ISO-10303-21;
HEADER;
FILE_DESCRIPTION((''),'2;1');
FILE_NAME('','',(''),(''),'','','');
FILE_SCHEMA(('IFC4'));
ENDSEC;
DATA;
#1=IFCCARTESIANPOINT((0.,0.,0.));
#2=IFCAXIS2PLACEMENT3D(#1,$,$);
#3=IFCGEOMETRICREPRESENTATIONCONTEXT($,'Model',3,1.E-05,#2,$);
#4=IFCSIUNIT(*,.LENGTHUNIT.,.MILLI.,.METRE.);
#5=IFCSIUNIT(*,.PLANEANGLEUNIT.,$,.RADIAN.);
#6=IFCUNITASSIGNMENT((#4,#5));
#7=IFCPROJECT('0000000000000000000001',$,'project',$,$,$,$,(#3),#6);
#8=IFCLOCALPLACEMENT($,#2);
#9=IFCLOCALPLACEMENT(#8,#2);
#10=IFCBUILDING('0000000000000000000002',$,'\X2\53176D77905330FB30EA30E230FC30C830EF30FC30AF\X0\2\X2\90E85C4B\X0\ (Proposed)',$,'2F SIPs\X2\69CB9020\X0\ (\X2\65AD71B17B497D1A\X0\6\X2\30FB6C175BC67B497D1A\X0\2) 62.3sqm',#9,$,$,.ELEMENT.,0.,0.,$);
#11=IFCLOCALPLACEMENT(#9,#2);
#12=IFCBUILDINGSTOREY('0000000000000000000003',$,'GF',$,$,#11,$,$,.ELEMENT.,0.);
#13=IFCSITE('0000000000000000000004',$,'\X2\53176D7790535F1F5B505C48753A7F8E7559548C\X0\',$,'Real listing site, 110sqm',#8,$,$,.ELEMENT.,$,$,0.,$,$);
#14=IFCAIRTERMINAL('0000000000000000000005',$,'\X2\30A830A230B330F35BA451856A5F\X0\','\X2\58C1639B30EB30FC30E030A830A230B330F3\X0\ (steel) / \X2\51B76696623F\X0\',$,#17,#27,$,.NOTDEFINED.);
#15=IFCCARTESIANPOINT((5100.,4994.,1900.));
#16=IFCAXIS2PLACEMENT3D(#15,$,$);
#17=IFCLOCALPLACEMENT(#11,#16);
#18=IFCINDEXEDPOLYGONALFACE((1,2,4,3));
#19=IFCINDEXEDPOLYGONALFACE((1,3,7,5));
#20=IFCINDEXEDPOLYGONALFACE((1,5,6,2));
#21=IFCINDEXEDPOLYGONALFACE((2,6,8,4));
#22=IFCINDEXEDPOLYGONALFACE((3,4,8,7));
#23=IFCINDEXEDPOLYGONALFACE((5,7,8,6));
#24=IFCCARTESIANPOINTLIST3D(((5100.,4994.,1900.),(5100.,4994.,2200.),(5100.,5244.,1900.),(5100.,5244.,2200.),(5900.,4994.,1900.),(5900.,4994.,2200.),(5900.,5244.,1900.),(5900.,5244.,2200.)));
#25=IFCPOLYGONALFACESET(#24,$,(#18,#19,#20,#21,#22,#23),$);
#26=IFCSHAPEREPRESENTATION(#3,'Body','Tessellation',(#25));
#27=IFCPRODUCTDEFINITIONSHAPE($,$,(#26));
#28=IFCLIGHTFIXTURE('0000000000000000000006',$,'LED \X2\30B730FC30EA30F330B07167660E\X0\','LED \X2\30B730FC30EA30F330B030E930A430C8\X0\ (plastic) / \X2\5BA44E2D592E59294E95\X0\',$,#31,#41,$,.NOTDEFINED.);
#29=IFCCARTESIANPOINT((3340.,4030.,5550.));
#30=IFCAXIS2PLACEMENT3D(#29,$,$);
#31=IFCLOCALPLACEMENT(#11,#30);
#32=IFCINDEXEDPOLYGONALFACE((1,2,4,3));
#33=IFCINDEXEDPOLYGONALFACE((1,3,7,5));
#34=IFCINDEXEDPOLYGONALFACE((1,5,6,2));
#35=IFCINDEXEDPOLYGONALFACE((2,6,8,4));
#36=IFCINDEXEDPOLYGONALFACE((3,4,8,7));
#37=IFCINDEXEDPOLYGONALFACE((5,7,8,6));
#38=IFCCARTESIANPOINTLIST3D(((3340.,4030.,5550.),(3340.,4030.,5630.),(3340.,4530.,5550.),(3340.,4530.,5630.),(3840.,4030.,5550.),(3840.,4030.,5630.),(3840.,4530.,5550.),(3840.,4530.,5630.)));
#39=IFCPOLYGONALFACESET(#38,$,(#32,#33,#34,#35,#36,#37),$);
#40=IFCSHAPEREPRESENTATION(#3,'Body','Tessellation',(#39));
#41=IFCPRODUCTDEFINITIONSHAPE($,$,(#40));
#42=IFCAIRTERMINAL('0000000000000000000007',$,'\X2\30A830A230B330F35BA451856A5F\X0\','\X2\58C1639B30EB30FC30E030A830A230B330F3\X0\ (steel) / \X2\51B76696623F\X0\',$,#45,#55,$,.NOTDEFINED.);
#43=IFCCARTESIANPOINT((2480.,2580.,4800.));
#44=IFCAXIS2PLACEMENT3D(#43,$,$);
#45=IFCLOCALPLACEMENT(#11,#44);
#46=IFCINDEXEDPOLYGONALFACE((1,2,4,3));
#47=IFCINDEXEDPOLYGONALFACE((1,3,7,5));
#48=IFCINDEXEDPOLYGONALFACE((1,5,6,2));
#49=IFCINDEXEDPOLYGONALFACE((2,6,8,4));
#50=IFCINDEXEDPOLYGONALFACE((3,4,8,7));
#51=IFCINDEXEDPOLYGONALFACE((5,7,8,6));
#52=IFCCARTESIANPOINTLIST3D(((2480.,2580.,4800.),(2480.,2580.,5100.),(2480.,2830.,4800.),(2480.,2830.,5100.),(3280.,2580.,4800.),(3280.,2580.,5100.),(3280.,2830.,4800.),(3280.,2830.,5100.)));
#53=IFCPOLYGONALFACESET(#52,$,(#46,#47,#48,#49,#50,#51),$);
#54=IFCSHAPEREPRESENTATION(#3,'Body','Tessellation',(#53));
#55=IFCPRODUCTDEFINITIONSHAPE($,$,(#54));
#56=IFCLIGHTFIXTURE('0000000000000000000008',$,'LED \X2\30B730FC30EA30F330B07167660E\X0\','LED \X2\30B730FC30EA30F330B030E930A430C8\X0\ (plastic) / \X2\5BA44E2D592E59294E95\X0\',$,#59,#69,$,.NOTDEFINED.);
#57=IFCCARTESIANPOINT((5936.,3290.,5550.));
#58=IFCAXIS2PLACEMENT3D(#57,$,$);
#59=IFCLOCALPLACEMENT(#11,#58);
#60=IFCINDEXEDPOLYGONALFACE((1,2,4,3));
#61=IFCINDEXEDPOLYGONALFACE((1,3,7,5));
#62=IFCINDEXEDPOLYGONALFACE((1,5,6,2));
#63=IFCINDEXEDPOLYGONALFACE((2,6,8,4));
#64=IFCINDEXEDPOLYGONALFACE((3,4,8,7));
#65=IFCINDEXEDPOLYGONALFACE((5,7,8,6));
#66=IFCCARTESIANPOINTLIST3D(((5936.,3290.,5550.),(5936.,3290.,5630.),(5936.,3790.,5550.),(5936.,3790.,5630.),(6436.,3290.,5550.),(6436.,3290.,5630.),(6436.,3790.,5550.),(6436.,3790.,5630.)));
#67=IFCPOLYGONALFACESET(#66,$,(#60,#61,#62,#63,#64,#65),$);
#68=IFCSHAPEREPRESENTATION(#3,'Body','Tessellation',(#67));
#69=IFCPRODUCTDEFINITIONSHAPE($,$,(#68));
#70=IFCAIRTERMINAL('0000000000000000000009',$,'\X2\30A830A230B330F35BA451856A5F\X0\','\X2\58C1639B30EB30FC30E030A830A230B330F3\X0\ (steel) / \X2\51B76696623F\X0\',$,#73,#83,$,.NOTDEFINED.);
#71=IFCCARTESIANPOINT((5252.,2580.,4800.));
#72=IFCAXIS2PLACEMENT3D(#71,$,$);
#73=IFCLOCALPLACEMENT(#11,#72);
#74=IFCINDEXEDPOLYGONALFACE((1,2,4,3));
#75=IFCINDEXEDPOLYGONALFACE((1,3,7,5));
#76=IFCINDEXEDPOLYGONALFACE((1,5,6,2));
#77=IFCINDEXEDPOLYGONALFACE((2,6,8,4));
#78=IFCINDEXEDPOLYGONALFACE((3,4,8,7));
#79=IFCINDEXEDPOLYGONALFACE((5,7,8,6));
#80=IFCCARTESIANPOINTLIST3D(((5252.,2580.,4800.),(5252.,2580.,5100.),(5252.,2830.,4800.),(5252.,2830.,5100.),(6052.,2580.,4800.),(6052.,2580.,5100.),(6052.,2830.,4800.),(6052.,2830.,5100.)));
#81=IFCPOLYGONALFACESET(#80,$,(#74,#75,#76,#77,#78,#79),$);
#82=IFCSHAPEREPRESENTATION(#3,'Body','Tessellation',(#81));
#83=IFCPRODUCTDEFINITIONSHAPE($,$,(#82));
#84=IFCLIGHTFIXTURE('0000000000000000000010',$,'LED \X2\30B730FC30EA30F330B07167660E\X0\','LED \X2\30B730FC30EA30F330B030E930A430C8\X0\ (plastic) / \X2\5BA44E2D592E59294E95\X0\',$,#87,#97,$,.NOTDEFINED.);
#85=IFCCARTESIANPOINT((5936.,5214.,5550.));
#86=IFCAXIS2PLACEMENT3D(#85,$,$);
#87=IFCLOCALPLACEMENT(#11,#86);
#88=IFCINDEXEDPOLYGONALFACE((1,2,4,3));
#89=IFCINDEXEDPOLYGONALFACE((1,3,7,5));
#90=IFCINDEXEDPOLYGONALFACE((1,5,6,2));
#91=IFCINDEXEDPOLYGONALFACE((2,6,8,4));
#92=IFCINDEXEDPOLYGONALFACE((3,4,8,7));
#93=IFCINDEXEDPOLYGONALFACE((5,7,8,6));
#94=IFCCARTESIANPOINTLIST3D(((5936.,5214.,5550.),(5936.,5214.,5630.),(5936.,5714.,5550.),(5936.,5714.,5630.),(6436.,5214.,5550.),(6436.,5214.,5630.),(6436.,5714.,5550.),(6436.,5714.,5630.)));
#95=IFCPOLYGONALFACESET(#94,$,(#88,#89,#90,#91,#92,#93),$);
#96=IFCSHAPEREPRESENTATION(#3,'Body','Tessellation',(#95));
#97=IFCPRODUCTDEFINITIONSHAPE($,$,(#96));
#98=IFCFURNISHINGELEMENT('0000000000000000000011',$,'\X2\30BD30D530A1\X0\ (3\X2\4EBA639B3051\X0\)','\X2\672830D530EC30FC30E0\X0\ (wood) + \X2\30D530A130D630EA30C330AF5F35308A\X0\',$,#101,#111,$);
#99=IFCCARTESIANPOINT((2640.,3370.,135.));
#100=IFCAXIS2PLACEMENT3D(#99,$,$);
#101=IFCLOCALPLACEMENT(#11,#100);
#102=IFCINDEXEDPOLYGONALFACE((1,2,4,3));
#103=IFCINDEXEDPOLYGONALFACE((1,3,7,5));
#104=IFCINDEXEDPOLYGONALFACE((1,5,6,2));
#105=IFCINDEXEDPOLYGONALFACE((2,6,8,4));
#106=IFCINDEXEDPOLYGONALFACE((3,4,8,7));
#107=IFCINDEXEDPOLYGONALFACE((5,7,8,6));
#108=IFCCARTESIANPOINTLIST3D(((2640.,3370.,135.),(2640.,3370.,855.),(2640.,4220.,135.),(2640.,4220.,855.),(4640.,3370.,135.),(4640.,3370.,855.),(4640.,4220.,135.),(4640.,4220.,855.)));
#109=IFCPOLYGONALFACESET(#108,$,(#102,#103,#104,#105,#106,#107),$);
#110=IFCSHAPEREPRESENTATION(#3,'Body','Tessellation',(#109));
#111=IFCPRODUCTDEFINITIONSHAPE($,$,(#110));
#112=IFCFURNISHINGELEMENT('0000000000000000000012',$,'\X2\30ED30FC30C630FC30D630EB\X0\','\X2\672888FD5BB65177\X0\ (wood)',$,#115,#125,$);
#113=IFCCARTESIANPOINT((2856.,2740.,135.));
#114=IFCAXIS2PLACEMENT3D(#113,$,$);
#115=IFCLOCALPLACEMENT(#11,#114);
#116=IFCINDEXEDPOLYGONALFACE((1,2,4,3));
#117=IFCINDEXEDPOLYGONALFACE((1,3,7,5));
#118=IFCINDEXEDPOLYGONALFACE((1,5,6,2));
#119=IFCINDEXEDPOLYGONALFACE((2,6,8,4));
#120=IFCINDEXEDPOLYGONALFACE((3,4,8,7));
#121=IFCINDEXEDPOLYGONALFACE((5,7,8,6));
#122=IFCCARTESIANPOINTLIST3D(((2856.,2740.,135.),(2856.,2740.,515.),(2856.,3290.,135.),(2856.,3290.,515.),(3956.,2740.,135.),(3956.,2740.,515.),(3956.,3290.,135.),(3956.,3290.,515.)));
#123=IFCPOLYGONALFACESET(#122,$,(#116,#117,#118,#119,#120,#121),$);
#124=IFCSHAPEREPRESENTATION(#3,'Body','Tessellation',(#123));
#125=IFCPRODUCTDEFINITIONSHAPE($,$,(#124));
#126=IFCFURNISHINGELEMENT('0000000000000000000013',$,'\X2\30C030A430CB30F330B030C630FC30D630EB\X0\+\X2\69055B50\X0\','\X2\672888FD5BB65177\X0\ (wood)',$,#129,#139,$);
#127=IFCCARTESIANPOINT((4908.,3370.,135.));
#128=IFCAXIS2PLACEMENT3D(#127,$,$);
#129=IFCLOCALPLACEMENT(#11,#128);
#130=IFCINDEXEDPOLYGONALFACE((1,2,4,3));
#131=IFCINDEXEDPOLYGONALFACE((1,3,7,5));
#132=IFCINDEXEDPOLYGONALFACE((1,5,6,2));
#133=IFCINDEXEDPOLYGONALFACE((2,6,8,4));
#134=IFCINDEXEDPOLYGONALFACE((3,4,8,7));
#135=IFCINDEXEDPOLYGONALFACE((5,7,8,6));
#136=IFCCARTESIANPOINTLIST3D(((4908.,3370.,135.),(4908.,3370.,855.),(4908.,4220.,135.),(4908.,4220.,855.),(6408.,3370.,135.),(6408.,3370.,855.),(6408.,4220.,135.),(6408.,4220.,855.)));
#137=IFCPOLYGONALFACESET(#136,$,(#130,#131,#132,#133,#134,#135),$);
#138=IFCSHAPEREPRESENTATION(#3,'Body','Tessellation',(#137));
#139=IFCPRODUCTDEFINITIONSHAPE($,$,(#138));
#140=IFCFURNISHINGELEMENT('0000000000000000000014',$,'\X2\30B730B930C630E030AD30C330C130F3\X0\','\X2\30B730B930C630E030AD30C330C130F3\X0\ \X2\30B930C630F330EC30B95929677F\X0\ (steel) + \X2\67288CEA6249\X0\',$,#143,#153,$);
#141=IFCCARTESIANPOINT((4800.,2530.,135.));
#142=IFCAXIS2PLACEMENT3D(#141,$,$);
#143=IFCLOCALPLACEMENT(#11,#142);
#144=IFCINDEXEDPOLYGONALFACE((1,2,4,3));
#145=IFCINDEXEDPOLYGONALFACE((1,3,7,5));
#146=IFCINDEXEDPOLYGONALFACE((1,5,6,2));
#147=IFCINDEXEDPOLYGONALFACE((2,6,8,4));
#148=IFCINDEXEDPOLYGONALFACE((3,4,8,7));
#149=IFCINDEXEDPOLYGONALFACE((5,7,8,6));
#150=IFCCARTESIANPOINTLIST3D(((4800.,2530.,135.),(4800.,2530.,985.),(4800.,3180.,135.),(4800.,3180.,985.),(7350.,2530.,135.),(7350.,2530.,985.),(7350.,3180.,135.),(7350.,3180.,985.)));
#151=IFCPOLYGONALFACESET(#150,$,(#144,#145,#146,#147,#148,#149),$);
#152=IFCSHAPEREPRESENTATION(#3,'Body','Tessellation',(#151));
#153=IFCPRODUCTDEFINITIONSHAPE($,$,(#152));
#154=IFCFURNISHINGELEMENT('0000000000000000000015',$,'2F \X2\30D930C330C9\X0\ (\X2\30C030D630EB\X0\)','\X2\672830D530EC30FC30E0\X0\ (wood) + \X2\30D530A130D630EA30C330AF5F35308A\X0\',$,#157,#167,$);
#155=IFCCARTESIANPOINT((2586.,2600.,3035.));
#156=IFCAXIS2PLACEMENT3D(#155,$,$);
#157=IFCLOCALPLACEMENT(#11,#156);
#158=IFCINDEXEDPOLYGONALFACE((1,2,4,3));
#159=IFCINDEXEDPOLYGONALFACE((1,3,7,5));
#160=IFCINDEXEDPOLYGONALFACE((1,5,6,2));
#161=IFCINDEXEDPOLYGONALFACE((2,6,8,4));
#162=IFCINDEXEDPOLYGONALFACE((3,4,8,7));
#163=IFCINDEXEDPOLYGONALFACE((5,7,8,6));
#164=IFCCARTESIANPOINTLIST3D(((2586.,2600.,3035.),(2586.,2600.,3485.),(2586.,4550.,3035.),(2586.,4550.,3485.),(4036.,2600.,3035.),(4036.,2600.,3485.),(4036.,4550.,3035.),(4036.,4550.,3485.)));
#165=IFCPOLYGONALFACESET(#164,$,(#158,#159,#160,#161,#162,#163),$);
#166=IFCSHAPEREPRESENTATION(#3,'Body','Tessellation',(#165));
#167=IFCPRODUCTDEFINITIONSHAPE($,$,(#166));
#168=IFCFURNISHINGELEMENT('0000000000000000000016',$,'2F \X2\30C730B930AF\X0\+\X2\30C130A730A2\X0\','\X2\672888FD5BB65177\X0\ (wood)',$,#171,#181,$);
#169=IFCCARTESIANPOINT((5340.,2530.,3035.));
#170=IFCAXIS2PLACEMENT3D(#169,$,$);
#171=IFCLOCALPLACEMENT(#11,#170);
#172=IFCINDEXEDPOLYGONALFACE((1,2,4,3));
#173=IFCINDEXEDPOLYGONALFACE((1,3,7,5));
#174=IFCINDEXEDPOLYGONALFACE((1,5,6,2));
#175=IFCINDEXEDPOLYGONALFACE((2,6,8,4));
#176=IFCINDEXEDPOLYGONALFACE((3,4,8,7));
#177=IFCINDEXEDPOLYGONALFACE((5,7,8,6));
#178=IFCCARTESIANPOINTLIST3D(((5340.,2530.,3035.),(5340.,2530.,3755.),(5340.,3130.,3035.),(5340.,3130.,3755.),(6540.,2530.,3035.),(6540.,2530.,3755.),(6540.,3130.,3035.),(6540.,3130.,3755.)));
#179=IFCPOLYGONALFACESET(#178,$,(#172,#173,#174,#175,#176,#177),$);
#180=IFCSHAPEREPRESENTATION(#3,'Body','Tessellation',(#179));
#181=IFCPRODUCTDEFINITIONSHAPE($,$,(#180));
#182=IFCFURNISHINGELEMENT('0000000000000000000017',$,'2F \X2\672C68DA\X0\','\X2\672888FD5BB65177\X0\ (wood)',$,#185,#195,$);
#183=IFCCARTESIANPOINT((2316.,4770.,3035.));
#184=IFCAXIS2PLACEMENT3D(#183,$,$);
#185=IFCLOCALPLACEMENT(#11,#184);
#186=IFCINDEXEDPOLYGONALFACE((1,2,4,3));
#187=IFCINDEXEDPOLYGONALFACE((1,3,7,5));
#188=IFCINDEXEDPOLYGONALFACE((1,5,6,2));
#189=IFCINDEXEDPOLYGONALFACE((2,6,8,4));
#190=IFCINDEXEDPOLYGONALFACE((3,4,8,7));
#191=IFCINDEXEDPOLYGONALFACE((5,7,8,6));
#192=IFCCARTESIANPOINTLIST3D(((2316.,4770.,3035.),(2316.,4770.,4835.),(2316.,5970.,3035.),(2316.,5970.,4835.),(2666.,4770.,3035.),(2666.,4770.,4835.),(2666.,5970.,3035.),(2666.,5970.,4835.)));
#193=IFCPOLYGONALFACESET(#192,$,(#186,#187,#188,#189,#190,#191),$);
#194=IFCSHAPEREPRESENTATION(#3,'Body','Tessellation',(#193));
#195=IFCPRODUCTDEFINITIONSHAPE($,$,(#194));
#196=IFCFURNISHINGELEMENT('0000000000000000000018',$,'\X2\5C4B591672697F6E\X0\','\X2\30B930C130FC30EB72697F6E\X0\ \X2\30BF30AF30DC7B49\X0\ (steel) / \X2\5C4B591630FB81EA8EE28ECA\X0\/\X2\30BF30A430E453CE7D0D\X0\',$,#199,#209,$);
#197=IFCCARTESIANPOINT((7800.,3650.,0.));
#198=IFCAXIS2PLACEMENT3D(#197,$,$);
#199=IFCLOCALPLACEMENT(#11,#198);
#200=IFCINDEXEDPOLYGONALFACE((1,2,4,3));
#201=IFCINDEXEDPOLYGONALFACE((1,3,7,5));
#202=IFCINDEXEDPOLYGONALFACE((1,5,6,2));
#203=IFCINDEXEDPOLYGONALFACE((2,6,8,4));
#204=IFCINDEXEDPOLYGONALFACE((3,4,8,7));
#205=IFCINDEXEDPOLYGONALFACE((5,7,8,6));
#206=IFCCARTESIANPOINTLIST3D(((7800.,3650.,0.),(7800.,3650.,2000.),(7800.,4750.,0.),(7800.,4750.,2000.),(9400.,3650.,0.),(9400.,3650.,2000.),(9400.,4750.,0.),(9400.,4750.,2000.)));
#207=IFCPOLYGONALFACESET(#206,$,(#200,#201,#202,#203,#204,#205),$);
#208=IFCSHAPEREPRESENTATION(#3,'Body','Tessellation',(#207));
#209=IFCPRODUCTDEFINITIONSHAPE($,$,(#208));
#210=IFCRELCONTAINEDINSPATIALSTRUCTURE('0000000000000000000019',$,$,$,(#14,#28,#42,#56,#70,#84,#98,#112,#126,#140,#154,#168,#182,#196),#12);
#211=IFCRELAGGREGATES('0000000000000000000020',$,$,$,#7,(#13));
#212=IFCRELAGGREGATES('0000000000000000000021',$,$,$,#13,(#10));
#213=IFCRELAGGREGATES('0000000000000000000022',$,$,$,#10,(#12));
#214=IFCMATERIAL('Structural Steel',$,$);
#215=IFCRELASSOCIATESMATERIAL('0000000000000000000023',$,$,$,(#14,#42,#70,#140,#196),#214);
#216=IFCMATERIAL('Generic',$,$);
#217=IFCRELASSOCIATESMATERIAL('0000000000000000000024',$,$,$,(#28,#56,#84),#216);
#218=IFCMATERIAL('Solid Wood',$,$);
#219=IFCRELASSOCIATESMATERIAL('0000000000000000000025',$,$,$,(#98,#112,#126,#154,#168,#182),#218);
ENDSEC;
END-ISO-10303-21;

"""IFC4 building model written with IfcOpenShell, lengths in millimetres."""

from ifc_helpers import new_model, si_unit, frame, frame_2d, origin, place, context, project, spatial, rectangle, extrude, material, element, save


model = new_model("IFC4")

# Units and contexts
model_context = context("Model", 3, precision=1e-05, world=origin())
ifc_project = project(units=[si_unit("LENGTHUNIT", "METRE", prefix="MILLI"), si_unit("PLANEANGLEUNIT", "RADIAN")], contexts=[model_context])

# Site, building, storey
site_placement = place(None, origin())
site = spatial("IfcSite", under=ifc_project, at=site_placement, Name="北海道弟子屈町美留和", ObjectType="Real listing site, 110sqm", CompositionType="ELEMENT", RefElevation=0.0)
building_placement = place(site_placement, origin())
building = spatial("IfcBuilding", under=site, at=building_placement, Name="北海道・リモートワーク2部屋 (Proposed)", ObjectType="2F SIPs構造 (断熱等級6・気密等級2) 62.3sqm", CompositionType="ELEMENT", ElevationOfRefHeight=0.0, ElevationOfTerrain=0.0)
storey_placement = place(building_placement, origin())
storey = spatial("IfcBuildingStorey", under=building, at=storey_placement, Name="GF", CompositionType="ELEMENT", Elevation=0.0)

# Shared definitions
ifc_material_1 = material(Name="Solid Wood")

# Shared definitions
ifc_material_2 = material(Name="Structural Steel")

# Shared definitions
ifc_material_3 = material(Name="Generic")

# Air terminal
air_terminal_1_placement = place(storey_placement, frame((5100.0, 4994.0, 1900.0)))
element("IfcAirTerminal", 1, at=air_terminal_1_placement, inside=storey, material=ifc_material_2, Name="エアコン室内機", Description="壁掛ルームエアコン (steel) / 冷暖房", PredefinedType="NOTDEFINED", context=model_context, shape_type="SweptSolid", body=[
    extrude(rectangle(XDim=800.0, YDim=250.0, at=frame_2d((400.0, 125.0))), frame((5100.0, 4994.0, 1900.0)), (0.0, 0.0, 1.0), 300.0),
])

# Light fixture
light_fixture_1_placement = place(storey_placement, frame((3340.0, 4030.0, 5550.0)))
element("IfcLightFixture", 2, at=light_fixture_1_placement, inside=storey, material=ifc_material_3, Name="LED シーリング照明", Description="LED シーリングライト (plastic) / 室中央天井", PredefinedType="NOTDEFINED", context=model_context, shape_type="SweptSolid", body=[
    extrude(rectangle(XDim=500.0, YDim=500.0, at=frame_2d((250.0, 250.0))), frame((3340.0, 4030.0, 5550.0)), (0.0, 0.0, 1.0), 80.0),
])

# Air terminal
air_terminal_2_placement = place(storey_placement, frame((2480.0, 2580.0, 4800.0)))
element("IfcAirTerminal", 3, at=air_terminal_2_placement, inside=storey, material=ifc_material_2, Name="エアコン室内機", Description="壁掛ルームエアコン (steel) / 冷暖房", PredefinedType="NOTDEFINED", context=model_context, shape_type="SweptSolid", body=[
    extrude(rectangle(XDim=800.0, YDim=250.0, at=frame_2d((400.0, 125.0))), frame((2480.0, 2580.0, 4800.0)), (0.0, 0.0, 1.0), 300.0),
])

# Light fixture
light_fixture_2_placement = place(storey_placement, frame((5936.0, 3290.0, 5550.0)))
element("IfcLightFixture", 4, at=light_fixture_2_placement, inside=storey, material=ifc_material_3, Name="LED シーリング照明", Description="LED シーリングライト (plastic) / 室中央天井", PredefinedType="NOTDEFINED", context=model_context, shape_type="SweptSolid", body=[
    extrude(rectangle(XDim=500.0, YDim=500.0, at=frame_2d((250.0, 250.0))), frame((5936.0, 3290.0, 5550.0)), (0.0, 0.0, 1.0), 80.0),
])

# Air terminal
air_terminal_3_placement = place(storey_placement, frame((5252.0, 2580.0, 4800.0)))
element("IfcAirTerminal", 5, at=air_terminal_3_placement, inside=storey, material=ifc_material_2, Name="エアコン室内機", Description="壁掛ルームエアコン (steel) / 冷暖房", PredefinedType="NOTDEFINED", context=model_context, shape_type="SweptSolid", body=[
    extrude(rectangle(XDim=800.0, YDim=250.0, at=frame_2d((400.0, 125.0))), frame((5252.0, 2580.0, 4800.0)), (0.0, 0.0, 1.0), 300.0),
])

# Light fixture
light_fixture_3_placement = place(storey_placement, frame((5936.0, 5214.0, 5550.0)))
element("IfcLightFixture", 6, at=light_fixture_3_placement, inside=storey, material=ifc_material_3, Name="LED シーリング照明", Description="LED シーリングライト (plastic) / 室中央天井", PredefinedType="NOTDEFINED", context=model_context, shape_type="SweptSolid", body=[
    extrude(rectangle(XDim=500.0, YDim=500.0, at=frame_2d((250.0, 250.0))), frame((5936.0, 5214.0, 5550.0)), (0.0, 0.0, 1.0), 80.0),
])

# Furnishing elements
furnishing_1_placement = place(storey_placement, frame((2640.0, 3370.0, 135.0)))
element("IfcFurnishingElement", 7, at=furnishing_1_placement, inside=storey, material=ifc_material_1, Name="ソファ (3人掛け)", Description="木フレーム (wood) + ファブリック張り", context=model_context, shape_type="SweptSolid", body=[
    extrude(rectangle(XDim=2000.0, YDim=850.0, at=frame_2d((1000.0, 425.0))), frame((2640.0, 3370.0, 135.0)), (0.0, 0.0, 1.0), 720.0),
])
furnishing_2_placement = place(storey_placement, frame((2856.0, 2740.0, 135.0)))
element("IfcFurnishingElement", 8, at=furnishing_2_placement, inside=storey, material=ifc_material_1, Name="ローテーブル", Description="木製家具 (wood)", context=model_context, shape_type="SweptSolid", body=[
    extrude(rectangle(XDim=1100.0, YDim=550.0, at=frame_2d((550.0, 275.0))), frame((2856.0, 2740.0, 135.0)), (0.0, 0.0, 1.0), 380.0),
])
furnishing_3_placement = place(storey_placement, frame((4908.0, 3370.0, 135.0)))
element("IfcFurnishingElement", 9, at=furnishing_3_placement, inside=storey, material=ifc_material_1, Name="ダイニングテーブル+椅子", Description="木製家具 (wood)", context=model_context, shape_type="SweptSolid", body=[
    extrude(rectangle(XDim=1500.0, YDim=850.0, at=frame_2d((750.0, 425.0))), frame((4908.0, 3370.0, 135.0)), (0.0, 0.0, 1.0), 720.0),
])
furnishing_4_placement = place(storey_placement, frame((4800.0, 2530.0, 135.0)))
element("IfcFurnishingElement", 10, at=furnishing_4_placement, inside=storey, material=ifc_material_2, Name="システムキッチン", Description="システムキッチン ステンレス天板 (steel) + 木質扉", context=model_context, shape_type="SweptSolid", body=[
    extrude(rectangle(XDim=2550.0, YDim=650.0, at=frame_2d((1275.0, 325.0))), frame((4800.0, 2530.0, 135.0)), (0.0, 0.0, 1.0), 850.0),
])
furnishing_5_placement = place(storey_placement, frame((2586.0, 2600.0, 3035.0)))
element("IfcFurnishingElement", 11, at=furnishing_5_placement, inside=storey, material=ifc_material_1, Name="2F ベッド (ダブル)", Description="木フレーム (wood) + ファブリック張り", context=model_context, shape_type="SweptSolid", body=[
    extrude(rectangle(XDim=1450.0, YDim=1950.0, at=frame_2d((725.0, 975.0))), frame((2586.0, 2600.0, 3035.0)), (0.0, 0.0, 1.0), 450.0),
])
furnishing_6_placement = place(storey_placement, frame((5340.0, 2530.0, 3035.0)))
element("IfcFurnishingElement", 12, at=furnishing_6_placement, inside=storey, material=ifc_material_1, Name="2F デスク+チェア", Description="木製家具 (wood)", context=model_context, shape_type="SweptSolid", body=[
    extrude(rectangle(XDim=1200.0, YDim=600.0, at=frame_2d((600.0, 300.0))), frame((5340.0, 2530.0, 3035.0)), (0.0, 0.0, 1.0), 720.0),
])
furnishing_7_placement = place(storey_placement, frame((2316.0, 4770.0, 3035.0)))
element("IfcFurnishingElement", 13, at=furnishing_7_placement, inside=storey, material=ifc_material_1, Name="2F 本棚", Description="木製家具 (wood)", context=model_context, shape_type="SweptSolid", body=[
    extrude(rectangle(XDim=350.0, YDim=1200.0, at=frame_2d((175.0, 600.0))), frame((2316.0, 4770.0, 3035.0)), (0.0, 0.0, 1.0), 1800.0),
])
furnishing_8_placement = place(storey_placement, frame((7800.0, 3650.0, 0.0)))
element("IfcFurnishingElement", 14, at=furnishing_8_placement, inside=storey, material=ifc_material_2, Name="屋外物置", Description="スチール物置 タクボ等 (steel) / 屋外・自転車/タイヤ収納", context=model_context, shape_type="SweptSolid", body=[
    extrude(rectangle(XDim=1600.0, YDim=1100.0, at=frame_2d((800.0, 550.0))), frame((7800.0, 3650.0, 0.0)), (0.0, 0.0, 1.0), 2000.0),
])

save(model, "model.ifc")
